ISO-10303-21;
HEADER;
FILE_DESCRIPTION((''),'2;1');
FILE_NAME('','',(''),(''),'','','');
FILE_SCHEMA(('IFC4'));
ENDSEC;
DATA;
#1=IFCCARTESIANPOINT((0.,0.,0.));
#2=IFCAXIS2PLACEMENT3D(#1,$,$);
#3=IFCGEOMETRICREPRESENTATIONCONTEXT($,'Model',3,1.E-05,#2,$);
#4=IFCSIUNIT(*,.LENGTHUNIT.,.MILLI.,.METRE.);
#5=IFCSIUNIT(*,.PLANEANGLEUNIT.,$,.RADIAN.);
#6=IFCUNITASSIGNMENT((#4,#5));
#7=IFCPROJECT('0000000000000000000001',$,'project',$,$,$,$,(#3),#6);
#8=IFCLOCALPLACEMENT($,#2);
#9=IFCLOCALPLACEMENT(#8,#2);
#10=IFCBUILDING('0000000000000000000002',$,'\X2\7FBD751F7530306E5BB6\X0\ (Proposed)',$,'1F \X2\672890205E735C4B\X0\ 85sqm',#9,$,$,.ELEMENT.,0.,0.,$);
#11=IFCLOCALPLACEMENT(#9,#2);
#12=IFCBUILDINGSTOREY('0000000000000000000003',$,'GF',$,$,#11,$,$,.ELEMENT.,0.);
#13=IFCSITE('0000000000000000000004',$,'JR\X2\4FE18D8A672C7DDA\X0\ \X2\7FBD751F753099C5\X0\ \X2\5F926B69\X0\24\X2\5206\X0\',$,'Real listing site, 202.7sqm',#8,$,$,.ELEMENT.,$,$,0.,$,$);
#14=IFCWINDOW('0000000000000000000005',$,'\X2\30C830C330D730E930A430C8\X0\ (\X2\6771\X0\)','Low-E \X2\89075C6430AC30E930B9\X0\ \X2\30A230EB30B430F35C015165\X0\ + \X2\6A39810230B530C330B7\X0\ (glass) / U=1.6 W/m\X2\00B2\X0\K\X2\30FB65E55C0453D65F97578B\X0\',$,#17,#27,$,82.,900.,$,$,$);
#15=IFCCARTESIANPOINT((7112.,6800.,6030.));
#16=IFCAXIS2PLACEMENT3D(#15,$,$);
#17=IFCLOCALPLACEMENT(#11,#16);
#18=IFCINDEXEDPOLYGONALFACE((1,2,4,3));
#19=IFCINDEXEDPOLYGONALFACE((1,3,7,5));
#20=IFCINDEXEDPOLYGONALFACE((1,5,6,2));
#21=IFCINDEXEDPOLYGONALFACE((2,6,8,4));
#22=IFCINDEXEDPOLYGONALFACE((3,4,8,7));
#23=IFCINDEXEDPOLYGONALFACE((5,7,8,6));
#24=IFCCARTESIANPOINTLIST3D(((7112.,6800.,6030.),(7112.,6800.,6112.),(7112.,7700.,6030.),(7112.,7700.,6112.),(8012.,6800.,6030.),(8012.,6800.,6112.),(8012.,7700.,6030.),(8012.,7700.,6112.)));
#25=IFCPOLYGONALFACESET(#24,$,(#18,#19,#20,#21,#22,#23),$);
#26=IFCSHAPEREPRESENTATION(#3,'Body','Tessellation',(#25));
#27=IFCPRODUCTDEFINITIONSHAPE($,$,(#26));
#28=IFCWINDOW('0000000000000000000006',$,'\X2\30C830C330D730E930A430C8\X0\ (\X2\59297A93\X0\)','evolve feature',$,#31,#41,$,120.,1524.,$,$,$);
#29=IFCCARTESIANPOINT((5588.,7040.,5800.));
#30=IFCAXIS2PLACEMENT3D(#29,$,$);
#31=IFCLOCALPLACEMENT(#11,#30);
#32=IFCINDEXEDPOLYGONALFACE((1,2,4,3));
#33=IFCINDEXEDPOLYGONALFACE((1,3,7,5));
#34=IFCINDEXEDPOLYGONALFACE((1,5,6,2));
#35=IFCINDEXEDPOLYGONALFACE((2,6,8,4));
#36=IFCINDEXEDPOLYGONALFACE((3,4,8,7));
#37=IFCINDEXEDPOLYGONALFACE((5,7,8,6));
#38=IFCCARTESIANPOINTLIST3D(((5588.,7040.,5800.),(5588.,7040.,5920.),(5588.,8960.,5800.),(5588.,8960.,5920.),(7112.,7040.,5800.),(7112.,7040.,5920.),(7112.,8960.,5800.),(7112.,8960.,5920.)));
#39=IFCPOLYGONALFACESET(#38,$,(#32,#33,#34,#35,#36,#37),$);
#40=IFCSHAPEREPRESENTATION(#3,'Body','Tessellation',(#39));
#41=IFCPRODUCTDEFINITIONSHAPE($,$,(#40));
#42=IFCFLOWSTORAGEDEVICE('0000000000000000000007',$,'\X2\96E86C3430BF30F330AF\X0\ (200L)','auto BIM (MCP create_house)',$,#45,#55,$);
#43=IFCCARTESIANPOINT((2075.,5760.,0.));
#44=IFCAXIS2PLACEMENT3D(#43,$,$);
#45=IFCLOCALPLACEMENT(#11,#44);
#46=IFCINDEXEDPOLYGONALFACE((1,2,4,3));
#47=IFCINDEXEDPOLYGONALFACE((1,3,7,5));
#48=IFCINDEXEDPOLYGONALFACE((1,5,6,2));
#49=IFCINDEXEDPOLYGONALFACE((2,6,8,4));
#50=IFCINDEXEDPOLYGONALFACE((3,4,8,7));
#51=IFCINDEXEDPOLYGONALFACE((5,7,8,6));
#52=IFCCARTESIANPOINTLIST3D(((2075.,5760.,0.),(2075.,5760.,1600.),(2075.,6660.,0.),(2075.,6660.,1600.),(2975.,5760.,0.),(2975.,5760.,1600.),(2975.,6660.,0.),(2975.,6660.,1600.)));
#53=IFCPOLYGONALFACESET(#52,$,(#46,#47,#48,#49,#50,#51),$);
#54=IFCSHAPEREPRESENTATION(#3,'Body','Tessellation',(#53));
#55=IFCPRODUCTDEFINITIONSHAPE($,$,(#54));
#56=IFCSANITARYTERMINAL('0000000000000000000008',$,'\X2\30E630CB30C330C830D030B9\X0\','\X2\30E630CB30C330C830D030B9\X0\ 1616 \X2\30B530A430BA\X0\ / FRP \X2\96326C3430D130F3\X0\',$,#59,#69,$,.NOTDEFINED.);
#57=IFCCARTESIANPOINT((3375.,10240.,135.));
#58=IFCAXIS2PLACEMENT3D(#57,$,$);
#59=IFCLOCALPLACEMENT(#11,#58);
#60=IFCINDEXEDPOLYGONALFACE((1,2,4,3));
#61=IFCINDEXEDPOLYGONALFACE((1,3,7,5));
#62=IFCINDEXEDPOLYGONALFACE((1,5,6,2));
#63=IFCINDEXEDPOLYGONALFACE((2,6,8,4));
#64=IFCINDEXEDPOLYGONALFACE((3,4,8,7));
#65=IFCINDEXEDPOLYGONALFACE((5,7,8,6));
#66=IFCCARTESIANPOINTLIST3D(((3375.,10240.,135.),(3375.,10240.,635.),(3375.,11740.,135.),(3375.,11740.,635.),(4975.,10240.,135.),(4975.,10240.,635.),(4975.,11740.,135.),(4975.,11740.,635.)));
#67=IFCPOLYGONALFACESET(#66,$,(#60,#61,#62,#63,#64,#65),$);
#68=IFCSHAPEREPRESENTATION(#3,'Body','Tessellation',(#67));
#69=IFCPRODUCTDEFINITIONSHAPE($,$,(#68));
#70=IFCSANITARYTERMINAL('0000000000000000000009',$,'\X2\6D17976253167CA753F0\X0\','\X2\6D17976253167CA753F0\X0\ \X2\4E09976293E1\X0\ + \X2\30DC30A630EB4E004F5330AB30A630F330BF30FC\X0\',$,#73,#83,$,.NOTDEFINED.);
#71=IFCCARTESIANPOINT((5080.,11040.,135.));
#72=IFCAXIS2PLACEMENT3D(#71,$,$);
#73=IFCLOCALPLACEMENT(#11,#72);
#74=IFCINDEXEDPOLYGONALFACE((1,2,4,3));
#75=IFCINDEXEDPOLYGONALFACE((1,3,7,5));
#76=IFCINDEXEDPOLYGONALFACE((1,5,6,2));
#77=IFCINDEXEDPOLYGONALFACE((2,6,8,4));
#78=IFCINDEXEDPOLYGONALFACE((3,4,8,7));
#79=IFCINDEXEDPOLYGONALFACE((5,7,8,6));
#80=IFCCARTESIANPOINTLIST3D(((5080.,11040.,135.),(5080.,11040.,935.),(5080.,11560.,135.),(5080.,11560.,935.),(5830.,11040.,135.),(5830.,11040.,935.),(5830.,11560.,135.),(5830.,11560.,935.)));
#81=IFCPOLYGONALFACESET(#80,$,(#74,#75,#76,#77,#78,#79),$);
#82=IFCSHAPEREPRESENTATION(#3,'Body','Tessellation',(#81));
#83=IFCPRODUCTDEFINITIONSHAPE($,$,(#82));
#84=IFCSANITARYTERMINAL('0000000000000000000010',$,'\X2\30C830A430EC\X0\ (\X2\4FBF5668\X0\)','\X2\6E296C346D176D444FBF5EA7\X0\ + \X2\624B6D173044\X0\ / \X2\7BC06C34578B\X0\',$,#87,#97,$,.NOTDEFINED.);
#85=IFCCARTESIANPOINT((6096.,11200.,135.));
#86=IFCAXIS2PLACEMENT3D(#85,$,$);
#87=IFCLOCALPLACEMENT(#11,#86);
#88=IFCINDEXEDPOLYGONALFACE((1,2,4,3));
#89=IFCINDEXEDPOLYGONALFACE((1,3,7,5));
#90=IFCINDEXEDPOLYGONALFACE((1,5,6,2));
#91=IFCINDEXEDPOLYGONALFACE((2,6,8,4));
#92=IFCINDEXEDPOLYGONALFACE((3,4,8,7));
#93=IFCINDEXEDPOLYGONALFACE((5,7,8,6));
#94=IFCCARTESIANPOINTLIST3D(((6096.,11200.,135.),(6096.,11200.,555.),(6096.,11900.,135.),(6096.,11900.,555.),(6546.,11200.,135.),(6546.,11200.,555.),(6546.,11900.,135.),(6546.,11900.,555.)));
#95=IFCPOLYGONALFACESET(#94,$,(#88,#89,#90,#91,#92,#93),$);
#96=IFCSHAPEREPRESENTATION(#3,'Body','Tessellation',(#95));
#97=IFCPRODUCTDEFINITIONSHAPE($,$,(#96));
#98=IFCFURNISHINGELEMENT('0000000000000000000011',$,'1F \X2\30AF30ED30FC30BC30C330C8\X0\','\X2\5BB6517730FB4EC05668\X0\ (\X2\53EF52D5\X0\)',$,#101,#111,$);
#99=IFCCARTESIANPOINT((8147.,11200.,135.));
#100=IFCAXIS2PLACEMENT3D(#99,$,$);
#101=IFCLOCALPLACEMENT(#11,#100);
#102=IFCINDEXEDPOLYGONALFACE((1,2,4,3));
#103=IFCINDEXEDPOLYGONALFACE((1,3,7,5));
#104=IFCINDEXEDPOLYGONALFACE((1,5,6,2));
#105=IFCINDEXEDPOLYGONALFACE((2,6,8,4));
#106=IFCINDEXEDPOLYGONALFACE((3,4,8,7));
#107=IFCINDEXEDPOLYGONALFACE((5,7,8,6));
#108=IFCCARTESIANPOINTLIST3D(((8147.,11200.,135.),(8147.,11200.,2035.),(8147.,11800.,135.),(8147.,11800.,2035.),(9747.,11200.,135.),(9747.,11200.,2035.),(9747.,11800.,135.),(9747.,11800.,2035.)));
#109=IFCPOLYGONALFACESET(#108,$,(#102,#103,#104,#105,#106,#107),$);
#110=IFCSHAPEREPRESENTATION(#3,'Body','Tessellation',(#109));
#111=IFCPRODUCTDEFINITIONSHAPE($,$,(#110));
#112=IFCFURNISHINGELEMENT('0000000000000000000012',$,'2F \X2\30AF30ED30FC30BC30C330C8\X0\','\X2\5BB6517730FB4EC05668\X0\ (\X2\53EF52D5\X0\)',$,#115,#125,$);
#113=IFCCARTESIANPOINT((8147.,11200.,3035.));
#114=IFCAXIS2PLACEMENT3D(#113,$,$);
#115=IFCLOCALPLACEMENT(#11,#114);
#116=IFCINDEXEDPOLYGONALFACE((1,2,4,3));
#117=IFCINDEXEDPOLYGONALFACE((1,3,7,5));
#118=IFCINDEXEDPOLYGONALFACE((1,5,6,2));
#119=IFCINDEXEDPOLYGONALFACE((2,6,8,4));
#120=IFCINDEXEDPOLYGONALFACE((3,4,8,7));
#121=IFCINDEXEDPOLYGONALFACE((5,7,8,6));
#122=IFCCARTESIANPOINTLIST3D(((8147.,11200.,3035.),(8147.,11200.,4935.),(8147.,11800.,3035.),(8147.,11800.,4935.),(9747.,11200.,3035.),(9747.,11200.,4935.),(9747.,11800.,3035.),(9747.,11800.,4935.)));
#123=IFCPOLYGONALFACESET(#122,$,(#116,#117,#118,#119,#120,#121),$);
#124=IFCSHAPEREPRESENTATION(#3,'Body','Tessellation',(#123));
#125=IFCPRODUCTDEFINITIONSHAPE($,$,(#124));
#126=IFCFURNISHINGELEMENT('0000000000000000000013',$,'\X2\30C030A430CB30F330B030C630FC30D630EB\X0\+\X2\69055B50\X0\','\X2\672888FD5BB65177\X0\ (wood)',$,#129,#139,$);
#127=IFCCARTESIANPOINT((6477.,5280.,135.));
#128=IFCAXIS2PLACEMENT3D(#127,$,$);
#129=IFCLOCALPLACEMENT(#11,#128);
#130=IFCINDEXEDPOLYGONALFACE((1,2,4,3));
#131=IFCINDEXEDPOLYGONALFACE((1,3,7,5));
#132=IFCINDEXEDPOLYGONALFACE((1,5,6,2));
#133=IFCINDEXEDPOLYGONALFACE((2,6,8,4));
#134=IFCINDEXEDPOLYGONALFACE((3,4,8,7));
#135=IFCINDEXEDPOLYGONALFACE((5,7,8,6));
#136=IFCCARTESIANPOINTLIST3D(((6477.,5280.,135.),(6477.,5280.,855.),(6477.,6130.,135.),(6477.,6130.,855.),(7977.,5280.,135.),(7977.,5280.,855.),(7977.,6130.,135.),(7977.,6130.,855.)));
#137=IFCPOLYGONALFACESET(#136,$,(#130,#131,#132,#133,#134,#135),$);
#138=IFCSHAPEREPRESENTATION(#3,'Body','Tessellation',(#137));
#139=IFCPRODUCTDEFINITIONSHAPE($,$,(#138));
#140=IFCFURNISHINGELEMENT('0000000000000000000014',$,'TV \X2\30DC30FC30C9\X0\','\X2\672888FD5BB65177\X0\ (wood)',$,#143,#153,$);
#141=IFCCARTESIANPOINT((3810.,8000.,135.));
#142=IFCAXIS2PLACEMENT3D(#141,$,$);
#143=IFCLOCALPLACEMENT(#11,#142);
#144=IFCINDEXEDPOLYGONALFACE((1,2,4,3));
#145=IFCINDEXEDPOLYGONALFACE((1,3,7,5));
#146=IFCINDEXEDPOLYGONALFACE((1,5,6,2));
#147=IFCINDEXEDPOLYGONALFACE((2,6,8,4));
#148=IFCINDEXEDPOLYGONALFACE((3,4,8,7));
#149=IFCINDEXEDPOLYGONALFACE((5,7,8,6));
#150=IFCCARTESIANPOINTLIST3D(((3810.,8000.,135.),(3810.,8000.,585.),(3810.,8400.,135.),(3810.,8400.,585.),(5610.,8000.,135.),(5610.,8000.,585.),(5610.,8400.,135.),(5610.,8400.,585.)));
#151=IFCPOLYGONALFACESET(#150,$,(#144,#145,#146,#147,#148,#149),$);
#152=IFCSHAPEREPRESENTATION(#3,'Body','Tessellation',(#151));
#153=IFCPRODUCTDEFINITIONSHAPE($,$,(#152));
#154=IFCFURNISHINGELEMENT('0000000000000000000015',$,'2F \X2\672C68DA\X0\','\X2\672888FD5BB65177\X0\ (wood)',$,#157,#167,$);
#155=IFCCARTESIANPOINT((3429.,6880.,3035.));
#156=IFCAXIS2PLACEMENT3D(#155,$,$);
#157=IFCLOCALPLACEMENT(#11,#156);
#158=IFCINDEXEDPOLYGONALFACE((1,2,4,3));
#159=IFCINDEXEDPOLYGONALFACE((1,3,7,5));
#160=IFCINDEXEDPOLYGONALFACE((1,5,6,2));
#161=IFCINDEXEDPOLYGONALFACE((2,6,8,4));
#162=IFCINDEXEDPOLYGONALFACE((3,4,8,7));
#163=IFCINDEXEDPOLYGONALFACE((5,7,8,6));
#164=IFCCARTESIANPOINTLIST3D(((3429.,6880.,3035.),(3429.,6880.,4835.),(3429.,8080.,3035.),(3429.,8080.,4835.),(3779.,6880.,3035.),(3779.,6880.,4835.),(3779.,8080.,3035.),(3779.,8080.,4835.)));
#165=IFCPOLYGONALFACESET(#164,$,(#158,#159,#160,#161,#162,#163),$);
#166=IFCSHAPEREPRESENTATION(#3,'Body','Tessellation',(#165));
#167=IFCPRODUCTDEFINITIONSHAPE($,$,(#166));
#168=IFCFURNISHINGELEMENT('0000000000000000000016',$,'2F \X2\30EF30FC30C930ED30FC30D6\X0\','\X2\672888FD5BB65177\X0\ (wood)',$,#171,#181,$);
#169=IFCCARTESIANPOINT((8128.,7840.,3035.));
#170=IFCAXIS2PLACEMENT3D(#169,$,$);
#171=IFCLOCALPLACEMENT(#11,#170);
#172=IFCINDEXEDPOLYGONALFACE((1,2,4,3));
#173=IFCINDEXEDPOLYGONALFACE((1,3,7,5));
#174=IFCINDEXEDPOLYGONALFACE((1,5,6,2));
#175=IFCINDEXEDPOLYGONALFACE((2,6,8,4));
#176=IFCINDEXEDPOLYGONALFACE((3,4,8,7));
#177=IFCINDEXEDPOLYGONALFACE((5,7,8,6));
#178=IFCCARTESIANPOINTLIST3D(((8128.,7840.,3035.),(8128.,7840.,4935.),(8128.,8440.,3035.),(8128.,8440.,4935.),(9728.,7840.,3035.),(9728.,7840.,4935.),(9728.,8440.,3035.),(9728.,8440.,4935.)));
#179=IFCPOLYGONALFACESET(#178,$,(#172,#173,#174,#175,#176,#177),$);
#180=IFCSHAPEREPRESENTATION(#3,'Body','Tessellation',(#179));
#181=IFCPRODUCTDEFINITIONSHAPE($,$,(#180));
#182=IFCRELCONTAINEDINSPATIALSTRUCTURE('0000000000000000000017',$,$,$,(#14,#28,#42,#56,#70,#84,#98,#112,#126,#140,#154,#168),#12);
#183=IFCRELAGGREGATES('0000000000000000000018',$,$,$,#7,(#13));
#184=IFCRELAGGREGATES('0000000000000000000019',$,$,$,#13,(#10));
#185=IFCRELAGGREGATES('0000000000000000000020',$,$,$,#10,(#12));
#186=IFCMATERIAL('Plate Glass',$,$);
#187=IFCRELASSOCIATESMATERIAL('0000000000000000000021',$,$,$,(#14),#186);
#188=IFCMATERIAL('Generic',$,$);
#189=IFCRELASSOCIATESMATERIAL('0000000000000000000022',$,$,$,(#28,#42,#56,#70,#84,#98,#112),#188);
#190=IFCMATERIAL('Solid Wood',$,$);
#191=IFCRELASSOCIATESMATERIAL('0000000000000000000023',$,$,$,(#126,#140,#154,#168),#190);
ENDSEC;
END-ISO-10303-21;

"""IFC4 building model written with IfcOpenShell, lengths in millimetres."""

from ifc_helpers import new_model, si_unit, frame, frame_2d, origin, place, context, project, spatial, rectangle, extrude, material, element, save


model = new_model("IFC4")

# Units and contexts
model_context = context("Model", 3, precision=1e-05, world=origin())
ifc_project = project(units=[si_unit("LENGTHUNIT", "METRE", prefix="MILLI"), si_unit("PLANEANGLEUNIT", "RADIAN")], contexts=[model_context])

# Site, building, storey
site_placement = place(None, origin())
site = spatial("IfcSite", under=ifc_project, at=site_placement, Name="JR信越本線 羽生田駅 徒歩24分", ObjectType="Real listing site, 202.7sqm", CompositionType="ELEMENT", RefElevation=0.0)
building_placement = place(site_placement, origin())
building = spatial("IfcBuilding", under=site, at=building_placement, Name="羽生田の家 (Proposed)", ObjectType="1F 木造平屋 85sqm", CompositionType="ELEMENT", ElevationOfRefHeight=0.0, ElevationOfTerrain=0.0)
storey_placement = place(building_placement, origin())
storey = spatial("IfcBuildingStorey", under=building, at=storey_placement, Name="GF", CompositionType="ELEMENT", Elevation=0.0)

# Shared definitions
ifc_material_1 = material(Name="Solid Wood")
ifc_material_2 = material(Name="Plate Glass")

# Windows
window_1_placement = place(storey_placement, frame((7112.0, 6800.0, 6030.0)))
element("IfcWindow", 1, at=window_1_placement, inside=storey, material=ifc_material_2, Name="トップライト (東)", Description="Low-E 複層ガラス アルゴン封入 + 樹脂サッシ (glass) / U=1.6 W/m²K・日射取得型", OverallHeight=82.0, OverallWidth=900.0, context=model_context, shape_type="SweptSolid", body=[
    extrude(rectangle(XDim=900.0, YDim=900.0, at=frame_2d((450.0, 450.0))), frame((7112.0, 6800.0, 6030.0)), (0.0, 0.0, 1.0), 82.0),
])
ifc_material_3 = material(Name="Generic")
window_2_placement = place(storey_placement, frame((5588.0, 7040.0, 5800.0)))
element("IfcWindow", 2, at=window_2_placement, inside=storey, material=ifc_material_3, Name="トップライト (天窓)", Description="evolve feature", OverallHeight=120.0, OverallWidth=1524.0, context=model_context, shape_type="SweptSolid", body=[
    extrude(rectangle(XDim=1524.0, YDim=1920.0, at=frame_2d((762.0, 960.0))), frame((5588.0, 7040.0, 5800.0)), (0.0, 0.0, 1.0), 120.0),
])

# Flow storage device
flow_storage_device_placement = place(storey_placement, frame((2075.0, 5760.0, 0.0)))
element("IfcFlowStorageDevice", 3, at=flow_storage_device_placement, inside=storey, material=ifc_material_3, Name="雨水タンク (200L)", Description="auto BIM (MCP create_house)", context=model_context, shape_type="SweptSolid", body=[
    extrude(rectangle(XDim=900.0, YDim=900.0, at=frame_2d((450.0, 450.0))), frame((2075.0, 5760.0, 0.0)), (0.0, 0.0, 1.0), 1600.0),
])

# Sanitary terminals
sanitary_terminal_1_placement = place(storey_placement, frame((3375.0, 10240.0, 135.0)))
element("IfcSanitaryTerminal", 4, at=sanitary_terminal_1_placement, inside=storey, material=ifc_material_3, Name="ユニットバス", Description="ユニットバス 1616 サイズ / FRP 防水パン", PredefinedType="NOTDEFINED", context=model_context, shape_type="SweptSolid", body=[
    extrude(rectangle(XDim=1600.0, YDim=1500.0, at=frame_2d((800.0, 750.0))), frame((3375.0, 10240.0, 135.0)), (0.0, 0.0, 1.0), 500.0),
])
sanitary_terminal_2_placement = place(storey_placement, frame((5080.0, 11040.0, 135.0)))
element("IfcSanitaryTerminal", 5, at=sanitary_terminal_2_placement, inside=storey, material=ifc_material_3, Name="洗面化粧台", Description="洗面化粧台 三面鏡 + ボウル一体カウンター", PredefinedType="NOTDEFINED", context=model_context, shape_type="SweptSolid", body=[
    extrude(rectangle(XDim=750.0, YDim=520.0, at=frame_2d((375.0, 260.0))), frame((5080.0, 11040.0, 135.0)), (0.0, 0.0, 1.0), 800.0),
])
sanitary_terminal_3_placement = place(storey_placement, frame((6096.0, 11200.0, 135.0)))
element("IfcSanitaryTerminal", 6, at=sanitary_terminal_3_placement, inside=storey, material=ifc_material_3, Name="トイレ (便器)", Description="温水洗浄便座 + 手洗い / 節水型", PredefinedType="NOTDEFINED", context=model_context, shape_type="SweptSolid", body=[
    extrude(rectangle(XDim=450.0, YDim=700.0, at=frame_2d((225.0, 350.0))), frame((6096.0, 11200.0, 135.0)), (0.0, 0.0, 1.0), 420.0),
])

# Furnishing elements
furnishing_1_placement = place(storey_placement, frame((8147.0, 11200.0, 135.0)))
element("IfcFurnishingElement", 7, at=furnishing_1_placement, inside=storey, material=ifc_material_3, Name="1F クローゼット", Description="家具・什器 (可動)", context=model_context, shape_type="SweptSolid", body=[
    extrude(rectangle(XDim=1600.0, YDim=600.0, at=frame_2d((800.0, 300.0))), frame((8147.0, 11200.0, 135.0)), (0.0, 0.0, 1.0), 1900.0),
])
furnishing_2_placement = place(storey_placement, frame((8147.0, 11200.0, 3035.0)))
element("IfcFurnishingElement", 8, at=furnishing_2_placement, inside=storey, material=ifc_material_3, Name="2F クローゼット", Description="家具・什器 (可動)", context=model_context, shape_type="SweptSolid", body=[
    extrude(rectangle(XDim=1600.0, YDim=600.0, at=frame_2d((800.0, 300.0))), frame((8147.0, 11200.0, 3035.0)), (0.0, 0.0, 1.0), 1900.0),
])
furnishing_3_placement = place(storey_placement, frame((6477.0, 5280.0, 135.0)))
element("IfcFurnishingElement", 9, at=furnishing_3_placement, inside=storey, material=ifc_material_1, Name="ダイニングテーブル+椅子", Description="木製家具 (wood)", context=model_context, shape_type="SweptSolid", body=[
    extrude(rectangle(XDim=1500.0, YDim=850.0, at=frame_2d((750.0, 425.0))), frame((6477.0, 5280.0, 135.0)), (0.0, 0.0, 1.0), 720.0),
])
furnishing_4_placement = place(storey_placement, frame((3810.0, 8000.0, 135.0)))
element("IfcFurnishingElement", 10, at=furnishing_4_placement, inside=storey, material=ifc_material_1, Name="TV ボード", Description="木製家具 (wood)", context=model_context, shape_type="SweptSolid", body=[
    extrude(rectangle(XDim=1800.0, YDim=400.0, at=frame_2d((900.0, 200.0))), frame((3810.0, 8000.0, 135.0)), (0.0, 0.0, 1.0), 450.0),
])
furnishing_5_placement = place(storey_placement, frame((3429.0, 6880.0, 3035.0)))
element("IfcFurnishingElement", 11, at=furnishing_5_placement, inside=storey, material=ifc_material_1, Name="2F 本棚", Description="木製家具 (wood)", context=model_context, shape_type="SweptSolid", body=[
    extrude(rectangle(XDim=350.0, YDim=1200.0, at=frame_2d((175.0, 600.0))), frame((3429.0, 6880.0, 3035.0)), (0.0, 0.0, 1.0), 1800.0),
])
furnishing_6_placement = place(storey_placement, frame((8128.0, 7840.0, 3035.0)))
element("IfcFurnishingElement", 12, at=furnishing_6_placement, inside=storey, material=ifc_material_1, Name="2F ワードローブ", Description="木製家具 (wood)", context=model_context, shape_type="SweptSolid", body=[
    extrude(rectangle(XDim=1600.0, YDim=600.0, at=frame_2d((800.0, 300.0))), frame((8128.0, 7840.0, 3035.0)), (0.0, 0.0, 1.0), 1900.0),
])

save(model, "model.ifc")
